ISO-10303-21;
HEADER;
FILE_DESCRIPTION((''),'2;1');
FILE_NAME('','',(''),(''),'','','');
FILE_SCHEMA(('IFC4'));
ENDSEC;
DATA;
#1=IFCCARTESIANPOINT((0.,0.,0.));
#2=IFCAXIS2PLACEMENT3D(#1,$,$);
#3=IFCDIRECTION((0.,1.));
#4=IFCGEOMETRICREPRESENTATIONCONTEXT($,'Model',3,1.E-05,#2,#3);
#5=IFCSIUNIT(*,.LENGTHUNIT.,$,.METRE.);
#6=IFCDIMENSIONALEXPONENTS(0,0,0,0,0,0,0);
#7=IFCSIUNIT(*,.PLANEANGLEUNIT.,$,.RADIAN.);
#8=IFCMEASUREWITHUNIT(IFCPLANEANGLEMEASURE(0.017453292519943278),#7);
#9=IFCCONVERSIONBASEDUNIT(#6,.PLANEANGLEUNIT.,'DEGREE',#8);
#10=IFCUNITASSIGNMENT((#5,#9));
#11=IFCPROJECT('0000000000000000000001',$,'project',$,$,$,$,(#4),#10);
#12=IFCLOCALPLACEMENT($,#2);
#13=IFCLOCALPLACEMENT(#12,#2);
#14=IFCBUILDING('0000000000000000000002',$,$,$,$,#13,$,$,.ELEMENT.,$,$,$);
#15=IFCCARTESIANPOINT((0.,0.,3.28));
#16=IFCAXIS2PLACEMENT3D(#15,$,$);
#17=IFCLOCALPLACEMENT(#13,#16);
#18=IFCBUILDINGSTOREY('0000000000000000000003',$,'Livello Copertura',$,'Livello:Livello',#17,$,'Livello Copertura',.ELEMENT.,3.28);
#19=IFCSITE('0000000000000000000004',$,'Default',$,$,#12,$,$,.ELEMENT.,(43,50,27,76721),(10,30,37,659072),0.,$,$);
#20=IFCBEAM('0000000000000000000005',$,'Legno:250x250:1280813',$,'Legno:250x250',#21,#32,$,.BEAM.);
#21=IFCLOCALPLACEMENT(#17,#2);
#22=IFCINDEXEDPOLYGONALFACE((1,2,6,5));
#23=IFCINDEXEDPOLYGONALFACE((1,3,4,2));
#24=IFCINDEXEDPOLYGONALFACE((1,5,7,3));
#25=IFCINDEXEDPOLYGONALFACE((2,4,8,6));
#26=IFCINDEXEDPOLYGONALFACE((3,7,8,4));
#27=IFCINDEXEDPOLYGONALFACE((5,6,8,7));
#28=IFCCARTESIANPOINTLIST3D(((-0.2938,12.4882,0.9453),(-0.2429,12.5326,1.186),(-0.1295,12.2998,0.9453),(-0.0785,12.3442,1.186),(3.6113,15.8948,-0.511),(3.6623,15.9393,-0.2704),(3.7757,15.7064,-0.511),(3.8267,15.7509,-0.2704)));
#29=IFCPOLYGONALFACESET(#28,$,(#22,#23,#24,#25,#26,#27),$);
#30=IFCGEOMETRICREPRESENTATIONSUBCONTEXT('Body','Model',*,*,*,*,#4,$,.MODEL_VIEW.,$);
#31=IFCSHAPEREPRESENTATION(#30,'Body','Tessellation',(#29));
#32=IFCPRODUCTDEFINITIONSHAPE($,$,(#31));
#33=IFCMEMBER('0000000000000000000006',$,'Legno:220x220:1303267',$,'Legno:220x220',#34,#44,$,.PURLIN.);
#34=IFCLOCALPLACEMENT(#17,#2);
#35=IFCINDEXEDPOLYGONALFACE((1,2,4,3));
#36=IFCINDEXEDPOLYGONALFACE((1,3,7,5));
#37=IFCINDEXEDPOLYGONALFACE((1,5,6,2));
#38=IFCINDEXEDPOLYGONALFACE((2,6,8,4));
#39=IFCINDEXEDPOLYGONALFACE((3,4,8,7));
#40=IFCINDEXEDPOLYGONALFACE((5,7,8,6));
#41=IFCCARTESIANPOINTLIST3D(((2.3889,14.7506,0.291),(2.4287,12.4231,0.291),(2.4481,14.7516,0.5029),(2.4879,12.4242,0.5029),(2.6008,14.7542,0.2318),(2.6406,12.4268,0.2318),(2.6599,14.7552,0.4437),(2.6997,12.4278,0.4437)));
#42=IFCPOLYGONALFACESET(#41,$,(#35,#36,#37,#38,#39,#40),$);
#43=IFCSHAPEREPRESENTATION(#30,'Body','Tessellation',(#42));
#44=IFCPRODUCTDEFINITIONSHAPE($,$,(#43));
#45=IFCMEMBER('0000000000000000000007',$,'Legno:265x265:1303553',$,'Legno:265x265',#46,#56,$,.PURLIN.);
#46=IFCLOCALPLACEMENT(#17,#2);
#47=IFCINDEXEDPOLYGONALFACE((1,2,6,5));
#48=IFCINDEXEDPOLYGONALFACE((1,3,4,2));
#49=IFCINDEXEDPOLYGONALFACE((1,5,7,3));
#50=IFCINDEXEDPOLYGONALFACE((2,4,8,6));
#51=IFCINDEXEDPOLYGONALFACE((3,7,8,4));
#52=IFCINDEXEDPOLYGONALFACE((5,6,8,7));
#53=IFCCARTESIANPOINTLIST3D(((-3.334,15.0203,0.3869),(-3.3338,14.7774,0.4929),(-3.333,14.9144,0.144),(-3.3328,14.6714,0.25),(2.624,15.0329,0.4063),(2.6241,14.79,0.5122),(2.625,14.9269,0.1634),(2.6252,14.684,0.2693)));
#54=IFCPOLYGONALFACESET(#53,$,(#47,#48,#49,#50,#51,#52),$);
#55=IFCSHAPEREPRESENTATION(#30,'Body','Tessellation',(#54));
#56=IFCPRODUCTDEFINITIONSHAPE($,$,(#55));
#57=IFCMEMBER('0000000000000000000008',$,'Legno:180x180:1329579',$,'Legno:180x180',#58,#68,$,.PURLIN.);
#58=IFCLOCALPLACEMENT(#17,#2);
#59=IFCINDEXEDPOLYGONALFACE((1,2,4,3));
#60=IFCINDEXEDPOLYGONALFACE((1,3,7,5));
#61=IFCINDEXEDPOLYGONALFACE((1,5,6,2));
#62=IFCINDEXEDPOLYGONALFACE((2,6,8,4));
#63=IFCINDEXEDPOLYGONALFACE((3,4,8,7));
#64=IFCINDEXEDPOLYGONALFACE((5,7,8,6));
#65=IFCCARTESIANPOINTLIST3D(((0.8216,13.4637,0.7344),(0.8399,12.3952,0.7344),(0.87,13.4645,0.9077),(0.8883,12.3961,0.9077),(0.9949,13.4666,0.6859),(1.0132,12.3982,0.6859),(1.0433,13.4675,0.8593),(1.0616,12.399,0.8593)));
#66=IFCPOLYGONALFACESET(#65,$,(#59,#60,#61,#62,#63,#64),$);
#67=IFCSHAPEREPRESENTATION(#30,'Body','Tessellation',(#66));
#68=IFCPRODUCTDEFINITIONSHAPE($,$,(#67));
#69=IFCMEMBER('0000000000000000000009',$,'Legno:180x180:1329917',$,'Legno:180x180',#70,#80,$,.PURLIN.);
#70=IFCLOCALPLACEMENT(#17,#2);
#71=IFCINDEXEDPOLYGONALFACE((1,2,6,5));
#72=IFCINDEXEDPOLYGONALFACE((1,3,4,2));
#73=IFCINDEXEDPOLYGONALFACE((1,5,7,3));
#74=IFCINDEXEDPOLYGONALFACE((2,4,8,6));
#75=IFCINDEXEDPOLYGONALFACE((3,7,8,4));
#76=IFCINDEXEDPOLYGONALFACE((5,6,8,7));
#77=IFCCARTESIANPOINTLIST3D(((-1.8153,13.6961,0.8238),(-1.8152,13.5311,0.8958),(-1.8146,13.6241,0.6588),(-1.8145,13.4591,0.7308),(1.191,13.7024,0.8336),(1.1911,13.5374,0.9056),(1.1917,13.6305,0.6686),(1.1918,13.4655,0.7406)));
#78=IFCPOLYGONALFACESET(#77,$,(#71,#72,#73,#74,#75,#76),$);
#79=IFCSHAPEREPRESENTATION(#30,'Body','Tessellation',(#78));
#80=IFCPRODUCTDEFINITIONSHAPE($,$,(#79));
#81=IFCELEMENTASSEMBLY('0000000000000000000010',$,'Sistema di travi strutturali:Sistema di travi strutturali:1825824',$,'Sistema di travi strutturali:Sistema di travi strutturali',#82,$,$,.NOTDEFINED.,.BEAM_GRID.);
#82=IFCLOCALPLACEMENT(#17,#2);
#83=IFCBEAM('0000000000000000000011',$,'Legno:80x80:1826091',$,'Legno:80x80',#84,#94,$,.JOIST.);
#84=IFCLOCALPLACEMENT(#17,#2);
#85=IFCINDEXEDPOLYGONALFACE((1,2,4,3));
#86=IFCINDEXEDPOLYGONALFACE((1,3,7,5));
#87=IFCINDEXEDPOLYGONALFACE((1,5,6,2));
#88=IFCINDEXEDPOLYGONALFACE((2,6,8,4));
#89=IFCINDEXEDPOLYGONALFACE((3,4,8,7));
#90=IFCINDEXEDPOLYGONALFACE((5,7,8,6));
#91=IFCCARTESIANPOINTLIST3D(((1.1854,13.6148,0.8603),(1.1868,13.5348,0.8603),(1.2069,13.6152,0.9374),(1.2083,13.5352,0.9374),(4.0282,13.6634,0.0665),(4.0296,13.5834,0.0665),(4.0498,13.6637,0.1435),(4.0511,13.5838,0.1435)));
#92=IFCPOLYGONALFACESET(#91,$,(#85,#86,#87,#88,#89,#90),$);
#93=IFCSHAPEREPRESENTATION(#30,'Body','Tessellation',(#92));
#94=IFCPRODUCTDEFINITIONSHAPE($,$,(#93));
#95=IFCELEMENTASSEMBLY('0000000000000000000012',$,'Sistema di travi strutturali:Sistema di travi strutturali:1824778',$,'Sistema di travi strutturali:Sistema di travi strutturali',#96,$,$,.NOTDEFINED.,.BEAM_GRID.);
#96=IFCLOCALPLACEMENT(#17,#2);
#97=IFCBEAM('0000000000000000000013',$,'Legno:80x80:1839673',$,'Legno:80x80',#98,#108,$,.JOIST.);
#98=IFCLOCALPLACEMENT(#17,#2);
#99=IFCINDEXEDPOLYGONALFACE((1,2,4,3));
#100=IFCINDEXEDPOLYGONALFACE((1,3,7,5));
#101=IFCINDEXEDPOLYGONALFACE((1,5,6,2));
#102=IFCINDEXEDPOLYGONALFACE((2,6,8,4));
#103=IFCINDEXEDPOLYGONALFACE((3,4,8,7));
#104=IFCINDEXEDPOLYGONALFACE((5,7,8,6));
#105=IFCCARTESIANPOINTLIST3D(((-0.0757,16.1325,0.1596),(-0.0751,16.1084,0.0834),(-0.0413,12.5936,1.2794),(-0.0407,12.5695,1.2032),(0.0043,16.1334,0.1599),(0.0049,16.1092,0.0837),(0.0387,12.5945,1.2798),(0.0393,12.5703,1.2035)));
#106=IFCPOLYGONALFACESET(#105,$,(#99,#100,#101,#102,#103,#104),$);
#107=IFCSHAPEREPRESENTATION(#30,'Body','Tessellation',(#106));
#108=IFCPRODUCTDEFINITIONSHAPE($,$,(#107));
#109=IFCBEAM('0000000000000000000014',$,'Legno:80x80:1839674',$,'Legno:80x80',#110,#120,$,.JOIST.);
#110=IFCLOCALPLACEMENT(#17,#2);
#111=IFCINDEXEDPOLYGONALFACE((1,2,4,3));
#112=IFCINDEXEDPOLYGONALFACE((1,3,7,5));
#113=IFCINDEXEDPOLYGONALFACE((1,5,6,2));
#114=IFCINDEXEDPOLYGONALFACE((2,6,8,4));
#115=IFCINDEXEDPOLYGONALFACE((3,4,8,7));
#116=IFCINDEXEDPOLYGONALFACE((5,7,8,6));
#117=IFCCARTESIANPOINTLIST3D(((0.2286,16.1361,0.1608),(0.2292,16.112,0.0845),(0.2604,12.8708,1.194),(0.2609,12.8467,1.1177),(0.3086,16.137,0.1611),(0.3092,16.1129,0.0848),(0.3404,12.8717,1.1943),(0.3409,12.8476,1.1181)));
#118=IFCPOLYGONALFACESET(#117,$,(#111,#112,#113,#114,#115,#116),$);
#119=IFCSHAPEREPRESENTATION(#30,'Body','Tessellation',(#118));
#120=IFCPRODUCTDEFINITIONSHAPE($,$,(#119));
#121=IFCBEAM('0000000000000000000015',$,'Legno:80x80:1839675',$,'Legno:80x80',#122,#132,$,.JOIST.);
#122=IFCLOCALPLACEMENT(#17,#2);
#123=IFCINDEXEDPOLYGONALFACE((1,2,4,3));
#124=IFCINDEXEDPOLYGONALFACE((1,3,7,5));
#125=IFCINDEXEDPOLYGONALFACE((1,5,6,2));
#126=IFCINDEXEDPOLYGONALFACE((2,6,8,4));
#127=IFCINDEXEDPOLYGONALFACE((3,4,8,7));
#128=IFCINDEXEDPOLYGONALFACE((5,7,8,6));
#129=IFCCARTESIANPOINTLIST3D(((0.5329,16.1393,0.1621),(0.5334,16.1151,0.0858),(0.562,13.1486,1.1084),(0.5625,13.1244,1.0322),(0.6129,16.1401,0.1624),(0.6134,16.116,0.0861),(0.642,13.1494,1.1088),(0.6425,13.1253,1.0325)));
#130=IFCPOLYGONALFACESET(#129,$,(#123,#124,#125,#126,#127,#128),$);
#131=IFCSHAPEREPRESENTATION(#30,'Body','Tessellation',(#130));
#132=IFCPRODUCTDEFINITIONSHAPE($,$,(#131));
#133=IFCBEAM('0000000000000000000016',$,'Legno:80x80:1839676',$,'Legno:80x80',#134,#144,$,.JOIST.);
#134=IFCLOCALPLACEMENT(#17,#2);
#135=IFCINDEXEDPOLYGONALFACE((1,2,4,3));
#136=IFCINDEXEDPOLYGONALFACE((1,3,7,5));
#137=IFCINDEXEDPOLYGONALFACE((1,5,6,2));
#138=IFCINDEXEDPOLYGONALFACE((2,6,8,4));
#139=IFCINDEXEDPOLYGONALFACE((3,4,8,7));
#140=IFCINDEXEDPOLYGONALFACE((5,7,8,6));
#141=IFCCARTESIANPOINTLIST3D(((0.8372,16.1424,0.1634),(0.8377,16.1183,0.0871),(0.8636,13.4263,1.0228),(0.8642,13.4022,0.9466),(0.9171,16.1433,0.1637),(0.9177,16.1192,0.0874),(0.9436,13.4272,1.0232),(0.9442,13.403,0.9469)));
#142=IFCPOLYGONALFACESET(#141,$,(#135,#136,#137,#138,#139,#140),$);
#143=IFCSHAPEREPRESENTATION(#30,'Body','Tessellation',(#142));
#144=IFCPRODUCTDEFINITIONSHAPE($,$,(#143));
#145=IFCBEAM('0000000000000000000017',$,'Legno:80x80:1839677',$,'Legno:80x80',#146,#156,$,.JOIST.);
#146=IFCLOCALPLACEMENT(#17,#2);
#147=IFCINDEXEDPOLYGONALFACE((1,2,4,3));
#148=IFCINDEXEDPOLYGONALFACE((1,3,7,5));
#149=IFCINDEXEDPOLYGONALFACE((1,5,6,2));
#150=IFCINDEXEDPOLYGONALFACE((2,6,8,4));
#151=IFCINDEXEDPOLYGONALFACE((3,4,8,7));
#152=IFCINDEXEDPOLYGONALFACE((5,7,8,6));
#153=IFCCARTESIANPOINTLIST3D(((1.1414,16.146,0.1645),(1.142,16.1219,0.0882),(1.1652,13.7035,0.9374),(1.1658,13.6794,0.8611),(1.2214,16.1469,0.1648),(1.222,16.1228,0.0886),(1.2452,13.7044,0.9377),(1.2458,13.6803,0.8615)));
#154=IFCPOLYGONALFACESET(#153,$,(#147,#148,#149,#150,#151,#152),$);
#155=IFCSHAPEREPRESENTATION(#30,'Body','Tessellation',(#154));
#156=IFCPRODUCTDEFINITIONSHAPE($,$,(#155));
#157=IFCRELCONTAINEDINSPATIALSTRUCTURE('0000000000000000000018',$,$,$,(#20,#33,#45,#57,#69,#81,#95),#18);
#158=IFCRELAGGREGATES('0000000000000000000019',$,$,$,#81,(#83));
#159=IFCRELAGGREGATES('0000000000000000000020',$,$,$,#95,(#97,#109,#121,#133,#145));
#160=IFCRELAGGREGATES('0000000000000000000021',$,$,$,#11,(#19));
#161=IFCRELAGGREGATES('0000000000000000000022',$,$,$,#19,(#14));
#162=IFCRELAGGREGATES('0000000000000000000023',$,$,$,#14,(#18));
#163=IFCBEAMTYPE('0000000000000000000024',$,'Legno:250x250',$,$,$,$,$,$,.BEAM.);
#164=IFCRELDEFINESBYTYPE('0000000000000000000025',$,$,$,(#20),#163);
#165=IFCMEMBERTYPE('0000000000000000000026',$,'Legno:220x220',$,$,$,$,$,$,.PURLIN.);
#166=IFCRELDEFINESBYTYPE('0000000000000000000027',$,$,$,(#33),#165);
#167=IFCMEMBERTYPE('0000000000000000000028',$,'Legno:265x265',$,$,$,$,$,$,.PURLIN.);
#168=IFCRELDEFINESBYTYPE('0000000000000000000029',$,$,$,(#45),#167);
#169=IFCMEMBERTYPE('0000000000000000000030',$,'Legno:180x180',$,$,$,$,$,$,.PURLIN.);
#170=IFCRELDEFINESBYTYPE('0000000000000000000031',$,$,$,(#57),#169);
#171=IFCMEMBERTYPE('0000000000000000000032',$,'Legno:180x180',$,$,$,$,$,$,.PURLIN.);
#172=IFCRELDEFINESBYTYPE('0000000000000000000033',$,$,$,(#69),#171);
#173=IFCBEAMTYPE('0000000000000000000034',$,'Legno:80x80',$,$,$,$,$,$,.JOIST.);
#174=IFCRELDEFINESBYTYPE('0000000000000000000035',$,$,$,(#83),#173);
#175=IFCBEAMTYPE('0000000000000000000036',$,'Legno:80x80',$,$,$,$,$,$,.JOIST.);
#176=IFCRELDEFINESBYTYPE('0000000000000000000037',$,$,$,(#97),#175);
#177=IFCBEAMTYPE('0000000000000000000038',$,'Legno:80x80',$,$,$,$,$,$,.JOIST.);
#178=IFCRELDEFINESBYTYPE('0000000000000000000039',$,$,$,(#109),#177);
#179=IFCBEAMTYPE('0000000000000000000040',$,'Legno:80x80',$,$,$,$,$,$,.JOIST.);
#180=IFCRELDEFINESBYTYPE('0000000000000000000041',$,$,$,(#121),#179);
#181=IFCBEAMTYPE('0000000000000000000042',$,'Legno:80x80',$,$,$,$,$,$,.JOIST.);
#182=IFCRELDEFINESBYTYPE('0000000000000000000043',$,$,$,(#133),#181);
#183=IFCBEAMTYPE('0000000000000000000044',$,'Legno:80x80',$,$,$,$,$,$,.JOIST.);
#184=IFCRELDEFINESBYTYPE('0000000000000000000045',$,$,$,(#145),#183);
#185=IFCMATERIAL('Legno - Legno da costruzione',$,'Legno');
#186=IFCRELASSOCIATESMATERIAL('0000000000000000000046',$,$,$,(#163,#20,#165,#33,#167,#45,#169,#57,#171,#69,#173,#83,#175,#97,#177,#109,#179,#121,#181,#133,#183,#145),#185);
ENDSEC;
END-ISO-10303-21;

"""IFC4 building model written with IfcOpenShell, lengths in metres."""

from ifc_helpers import new_model, entity, si_unit, converted_unit, direction, frame, origin, place, context, subcontext, project, spatial, indexed_curve, outline, extrude, source, transform, mapped, material, type_object, type_shapes, element, aggregate, save


model = new_model("IFC4")

# Units and contexts
model_context = context("Model", 3, precision=1e-05, world=origin(), true_north=direction((0.0, 1.0)))
body_context = subcontext(model_context, "Body", "Model", "MODEL_VIEW")
ifc_project = project(units=[si_unit("LENGTHUNIT", "METRE"), converted_unit("PLANEANGLEUNIT", "DEGREE", entity("IfcPlaneAngleMeasure", 0.017453292519943278), si_unit("PLANEANGLEUNIT", "RADIAN"), dimensions=[0, 0, 0, 0, 0, 0, 0])], contexts=[model_context])

# Site, building, storey
site_placement = place(None, origin())
site = spatial("IfcSite", under=ifc_project, at=site_placement, Name="Default", CompositionType="ELEMENT", RefLatitude=(43, 50, 27, 76721), RefLongitude=(10, 30, 37, 659072), RefElevation=0.0)
building_placement = place(site_placement, origin())
building = spatial("IfcBuilding", under=site, at=building_placement, CompositionType="ELEMENT")
storey_placement = place(building_placement, frame((0.0, 0.0, 3.28)))
storey = spatial("IfcBuildingStorey", under=building, at=storey_placement, Name="Livello Copertura", ObjectType="Livello:Livello", LongName="Livello Copertura", CompositionType="ELEMENT", Elevation=3.28)

# Beam
ifc_material = material(Name="Legno - Legno da costruzione", Category="Legno")
beam_type_1 = type_object("IfcBeamType", Name="Legno:250x250", PredefinedType="BEAM", material=ifc_material)
shared_shape_1 = source(origin(), body_context, "Body", "SweptSolid", [
    extrude(outline(indexed_curve([(-0.125, -2.6915), (0.125, -2.6915), (0.125, 2.6915), (-0.125, 2.6915), (-0.125, -2.6915)], self_intersect=False)), frame((-0.097, 0.0, -0.125), z_axis=(0.0, 0.0, 1.0), x_axis=(0.0, 1.0, 0.0)), (0.0, 0.0, 1.0), 0.25),
])
type_shapes(beam_type_1, [shared_shape_1])
beam_1_placement = place(storey_placement, frame((1.696, 14.0581, 0.3637), z_axis=(0.203872, 0.177848, 0.962708), x_axis=(-0.725463, -0.632858, 0.270543)))
element("IfcBeam", 1, at=beam_1_placement, inside=storey, type_object=beam_type_1, material=ifc_material, Name="Legno:250x250:1280813", ObjectType="Legno:250x250", PredefinedType="BEAM", context=body_context, shape_type="MappedRepresentation", body=[
    mapped(shared_shape_1, transform((0.0, 0.0, 0.0), scale=1.0)),
])

# Members
member_type_1 = type_object("IfcMemberType", Name="Legno:220x220", PredefinedType="PURLIN", material=ifc_material)
shared_shape_2 = source(origin(), body_context, "Body", "SweptSolid", [
    extrude(outline(indexed_curve([(-1.1639, -0.11), (1.1639, -0.11), (1.1639, 0.11), (-1.1639, 0.11), (-1.1639, -0.11)], self_intersect=False)), frame((0.7551, 0.0, -0.11), z_axis=(0.0, 0.0, 1.0), x_axis=(-1.0, 0.0, 0.0)), (0.0, 0.0, 1.0), 0.22),
])
type_shapes(member_type_1, [shared_shape_2])
member_1_placement = place(storey_placement, frame((2.5314, 14.3442, 0.3673), z_axis=(0.268881, 0.004594, 0.963163), x_axis=(0.017085, -0.999854, 0.0)))
element("IfcMember", 2, at=member_1_placement, inside=storey, type_object=member_type_1, material=ifc_material, Name="Legno:220x220:1303267", ObjectType="Legno:220x220", PredefinedType="PURLIN", context=body_context, shape_type="MappedRepresentation", body=[
    mapped(shared_shape_2, transform((0.0, 0.0, 0.0), scale=1.0)),
])
member_type_2 = type_object("IfcMemberType", Name="Legno:265x265", PredefinedType="PURLIN", material=ifc_material)
shared_shape_3 = source(origin(), body_context, "Body", "SweptSolid", [
    extrude(outline(indexed_curve([(-2.979, -0.1325), (2.979, -0.1325), (2.979, 0.1325), (-2.979, 0.1325), (-2.979, -0.1325)], self_intersect=False)), frame((-0.0659, 0.0, -0.1325), z_axis=(0.0, 0.0, 1.0), x_axis=(-1.0, 0.0, 0.0)), (0.0, 0.0, 1.0), 0.265),
])
type_shapes(member_type_2, [shared_shape_3])
member_2_placement = place(storey_placement, frame((-0.2885, 14.8523, 0.3284), z_axis=(-0.003828, 0.399702, 0.916637), x_axis=(0.999992, 0.002114, 0.003254)))
element("IfcMember", 3, at=member_2_placement, inside=storey, type_object=member_type_2, material=ifc_material, Name="Legno:265x265:1303553", ObjectType="Legno:265x265", PredefinedType="PURLIN", context=body_context, shape_type="MappedRepresentation", body=[
    mapped(shared_shape_3, transform((0.0, 0.0, 0.0), scale=1.0)),
])
member_type_3 = type_object("IfcMemberType", Name="Legno:180x180", PredefinedType="PURLIN", material=ifc_material)
shared_shape_4 = source(origin(), body_context, "Body", "SweptSolid", [
    extrude(outline(indexed_curve([(-0.5343, -0.09), (0.5343, -0.09), (0.5343, 0.09), (-0.5343, 0.09), (-0.5343, -0.09)], self_intersect=False)), frame((1.3847, 0.0, -0.09), z_axis=(0.0, 0.0, 1.0), x_axis=(-1.0, 0.0, 0.0)), (0.0, 0.0, 1.0), 0.18),
])
type_shapes(member_type_3, [shared_shape_4])
member_3_placement = place(storey_placement, frame((0.9179, 14.3159, 0.7968), z_axis=(0.268881, 0.004594, 0.963163), x_axis=(0.017085, -0.999854, 0.0)))
element("IfcMember", 4, at=member_3_placement, inside=storey, type_object=member_type_3, material=ifc_material, Name="Legno:180x180:1329579", ObjectType="Legno:180x180", PredefinedType="PURLIN", context=body_context, shape_type="MappedRepresentation", body=[
    mapped(shared_shape_4, transform((0.0, 0.0, 0.0), scale=1.0)),
])
member_type_4 = type_object("IfcMemberType", Name="Legno:180x180", PredefinedType="PURLIN", material=ifc_material)
shared_shape_5 = source(origin(), body_context, "Body", "SweptSolid", [
    extrude(outline(indexed_curve([(-1.5032, -0.09), (1.5032, -0.09), (1.5032, 0.09), (-1.5032, 0.09), (-1.5032, -0.09)], self_intersect=False)), frame((-0.0234, 0.0, -0.09), z_axis=(0.0, 0.0, 1.0), x_axis=(-1.0, 0.0, 0.0)), (0.0, 0.0, 1.0), 0.18),
])
type_shapes(member_type_4, [shared_shape_5])
member_4_placement = place(storey_placement, frame((-0.2884, 13.5808, 0.7823), z_axis=(-0.003828, 0.399702, 0.916637), x_axis=(0.999992, 0.002114, 0.003254)))
element("IfcMember", 5, at=member_4_placement, inside=storey, type_object=member_type_4, material=ifc_material, Name="Legno:180x180:1329917", ObjectType="Legno:180x180", PredefinedType="PURLIN", context=body_context, shape_type="MappedRepresentation", body=[
    mapped(shared_shape_5, transform((0.0, 0.0, 0.0), scale=1.0)),
])

# Element assembly, beam
assembly_1_placement = place(storey_placement, origin())
assembly_1 = element("IfcElementAssembly", 6, at=assembly_1_placement, inside=storey, Name="Sistema di travi strutturali:Sistema di travi strutturali:1825824", ObjectType="Sistema di travi strutturali:Sistema di travi strutturali", AssemblyPlace="NOTDEFINED", PredefinedType="BEAM_GRID")
beam_type_2 = type_object("IfcBeamType", Name="Legno:80x80", PredefinedType="JOIST", material=ifc_material)
shared_shape_6 = source(origin(), body_context, "Body", "SweptSolid", [
    extrude(outline(indexed_curve([(-1.476, -0.04), (1.476, -0.04), (1.476, 0.04), (-1.476, 0.04), (-1.476, -0.04)], self_intersect=False)), frame((0.0, 0.0, -0.04), z_axis=(0.0, 0.0, 1.0), x_axis=(-1.0, 0.0, 0.0)), (0.0, 0.0, 1.0), 0.08),
])
type_shapes(beam_type_2, [shared_shape_6])
beam_2_placement = place(assembly_1_placement, frame((2.6183, 13.5993, 0.5019), z_axis=(0.268881, 0.004594, 0.963163), x_axis=(-0.963022, -0.016456, 0.26892)))
beam_2 = element("IfcBeam", 7, at=beam_2_placement, type_object=beam_type_2, material=ifc_material, Name="Legno:80x80:1826091", ObjectType="Legno:80x80", PredefinedType="JOIST", context=body_context, shape_type="MappedRepresentation", body=[
    mapped(shared_shape_6, transform((0.0, 0.0, 0.0), scale=1.0)),
])
aggregate(assembly_1, [beam_2])

# Element assembly, beams
assembly_2_placement = place(storey_placement, origin())
assembly_2 = element("IfcElementAssembly", 8, at=assembly_2_placement, inside=storey, Name="Sistema di travi strutturali:Sistema di travi strutturali:1824778", ObjectType="Sistema di travi strutturali:Sistema di travi strutturali", AssemblyPlace="NOTDEFINED", PredefinedType="BEAM_GRID")
beam_type_3 = type_object("IfcBeamType", Name="Legno:80x80", PredefinedType="JOIST", material=ifc_material)
shared_shape_7 = source(origin(), body_context, "Body", "SweptSolid", [
    extrude(outline(indexed_curve([(-1.856, -0.04), (1.856, -0.04), (1.856, 0.04), (-1.856, 0.04), (-1.856, -0.04)], self_intersect=False)), frame((0.0, 0.0, -0.04), z_axis=(0.0, 0.0, 1.0), x_axis=(-1.0, 0.0, 0.0)), (0.0, 0.0, 1.0), 0.08),
])
type_shapes(beam_type_3, [shared_shape_7])
beam_3_placement = place(assembly_2_placement, frame((-0.0182, 14.3514, 0.6816), z_axis=(-0.007187, 0.301619, 0.953402), x_axis=(0.009277, -0.953365, 0.301677)))
beam_3 = element("IfcBeam", 9, at=beam_3_placement, type_object=beam_type_3, material=ifc_material, Name="Legno:80x80:1839673", ObjectType="Legno:80x80", PredefinedType="JOIST", context=body_context, shape_type="MappedRepresentation", body=[
    mapped(shared_shape_7, transform((0.0, 0.0, 0.0), scale=1.0)),
])
beam_type_4 = type_object("IfcBeamType", Name="Legno:80x80", PredefinedType="JOIST", material=ifc_material)
shared_shape_8 = source(origin(), body_context, "Body", "SweptSolid", [
    extrude(outline(indexed_curve([(-1.7125, -0.04), (1.7125, -0.04), (1.7125, 0.04), (-1.7125, 0.04), (-1.7125, -0.04)], self_intersect=False)), frame((0.0, 0.0, -0.04), z_axis=(0.0, 0.0, 1.0), x_axis=(-1.0, 0.0, 0.0)), (0.0, 0.0, 1.0), 0.08),
])
type_shapes(beam_type_4, [shared_shape_8])
beam_4_placement = place(assembly_2_placement, frame((0.2848, 14.4919, 0.6394), z_axis=(-0.007187, 0.301619, 0.953402), x_axis=(0.009277, -0.953365, 0.301677)))
beam_4 = element("IfcBeam", 10, at=beam_4_placement, type_object=beam_type_4, material=ifc_material, Name="Legno:80x80:1839674", ObjectType="Legno:80x80", PredefinedType="JOIST", context=body_context, shape_type="MappedRepresentation", body=[
    mapped(shared_shape_8, transform((0.0, 0.0, 0.0), scale=1.0)),
])
beam_type_5 = type_object("IfcBeamType", Name="Legno:80x80", PredefinedType="JOIST", material=ifc_material)
shared_shape_9 = source(origin(), body_context, "Body", "SweptSolid", [
    extrude(outline(indexed_curve([(-1.5685, -0.04), (1.5685, -0.04), (1.5685, 0.04), (-1.5685, 0.04), (-1.5685, -0.04)], self_intersect=False)), frame((0.0, 0.0, -0.04), z_axis=(0.0, 0.0, 1.0), x_axis=(-1.0, 0.0, 0.0)), (0.0, 0.0, 1.0), 0.08),
])
type_shapes(beam_type_5, [shared_shape_9])
beam_5_placement = place(assembly_2_placement, frame((0.5877, 14.6323, 0.5973), z_axis=(-0.007187, 0.301619, 0.953402), x_axis=(0.009277, -0.953365, 0.301677)))
beam_5 = element("IfcBeam", 11, at=beam_5_placement, type_object=beam_type_5, material=ifc_material, Name="Legno:80x80:1839675", ObjectType="Legno:80x80", PredefinedType="JOIST", context=body_context, shape_type="MappedRepresentation", body=[
    mapped(shared_shape_9, transform((0.0, 0.0, 0.0), scale=1.0)),
])
beam_type_6 = type_object("IfcBeamType", Name="Legno:80x80", PredefinedType="JOIST", material=ifc_material)
shared_shape_10 = source(origin(), body_context, "Body", "SweptSolid", [
    extrude(outline(indexed_curve([(-1.4245, -0.04), (1.4245, -0.04), (1.4245, 0.04), (-1.4245, 0.04), (-1.4245, -0.04)], self_intersect=False)), frame((0.0, 0.0, -0.04), z_axis=(0.0, 0.0, 1.0), x_axis=(-1.0, 0.0, 0.0)), (0.0, 0.0, 1.0), 0.08),
])
type_shapes(beam_type_6, [shared_shape_10])
beam_6_placement = place(assembly_2_placement, frame((0.8907, 14.7727, 0.5551), z_axis=(-0.007187, 0.301619, 0.953402), x_axis=(0.009277, -0.953365, 0.301677)))
beam_6 = element("IfcBeam", 12, at=beam_6_placement, type_object=beam_type_6, material=ifc_material, Name="Legno:80x80:1839676", ObjectType="Legno:80x80", PredefinedType="JOIST", context=body_context, shape_type="MappedRepresentation", body=[
    mapped(shared_shape_10, transform((0.0, 0.0, 0.0), scale=1.0)),
])
beam_type_7 = type_object("IfcBeamType", Name="Legno:80x80", PredefinedType="JOIST", material=ifc_material)
shared_shape_11 = source(origin(), body_context, "Body", "SweptSolid", [
    extrude(outline(indexed_curve([(-1.281, -0.04), (1.281, -0.04), (1.281, 0.04), (-1.281, 0.04), (-1.281, -0.04)], self_intersect=False)), frame((0.0, 0.0, -0.04), z_axis=(0.0, 0.0, 1.0), x_axis=(-1.0, 0.0, 0.0)), (0.0, 0.0, 1.0), 0.08),
])
type_shapes(beam_type_7, [shared_shape_11])
beam_7_placement = place(assembly_2_placement, frame((1.1936, 14.9132, 0.513), z_axis=(-0.007187, 0.301619, 0.953402), x_axis=(0.009277, -0.953365, 0.301677)))
beam_7 = element("IfcBeam", 13, at=beam_7_placement, type_object=beam_type_7, material=ifc_material, Name="Legno:80x80:1839677", ObjectType="Legno:80x80", PredefinedType="JOIST", context=body_context, shape_type="MappedRepresentation", body=[
    mapped(shared_shape_11, transform((0.0, 0.0, 0.0), scale=1.0)),
])
aggregate(assembly_2, [beam_3, beam_4, beam_5, beam_6, beam_7])

save(model, "model.ifc")
